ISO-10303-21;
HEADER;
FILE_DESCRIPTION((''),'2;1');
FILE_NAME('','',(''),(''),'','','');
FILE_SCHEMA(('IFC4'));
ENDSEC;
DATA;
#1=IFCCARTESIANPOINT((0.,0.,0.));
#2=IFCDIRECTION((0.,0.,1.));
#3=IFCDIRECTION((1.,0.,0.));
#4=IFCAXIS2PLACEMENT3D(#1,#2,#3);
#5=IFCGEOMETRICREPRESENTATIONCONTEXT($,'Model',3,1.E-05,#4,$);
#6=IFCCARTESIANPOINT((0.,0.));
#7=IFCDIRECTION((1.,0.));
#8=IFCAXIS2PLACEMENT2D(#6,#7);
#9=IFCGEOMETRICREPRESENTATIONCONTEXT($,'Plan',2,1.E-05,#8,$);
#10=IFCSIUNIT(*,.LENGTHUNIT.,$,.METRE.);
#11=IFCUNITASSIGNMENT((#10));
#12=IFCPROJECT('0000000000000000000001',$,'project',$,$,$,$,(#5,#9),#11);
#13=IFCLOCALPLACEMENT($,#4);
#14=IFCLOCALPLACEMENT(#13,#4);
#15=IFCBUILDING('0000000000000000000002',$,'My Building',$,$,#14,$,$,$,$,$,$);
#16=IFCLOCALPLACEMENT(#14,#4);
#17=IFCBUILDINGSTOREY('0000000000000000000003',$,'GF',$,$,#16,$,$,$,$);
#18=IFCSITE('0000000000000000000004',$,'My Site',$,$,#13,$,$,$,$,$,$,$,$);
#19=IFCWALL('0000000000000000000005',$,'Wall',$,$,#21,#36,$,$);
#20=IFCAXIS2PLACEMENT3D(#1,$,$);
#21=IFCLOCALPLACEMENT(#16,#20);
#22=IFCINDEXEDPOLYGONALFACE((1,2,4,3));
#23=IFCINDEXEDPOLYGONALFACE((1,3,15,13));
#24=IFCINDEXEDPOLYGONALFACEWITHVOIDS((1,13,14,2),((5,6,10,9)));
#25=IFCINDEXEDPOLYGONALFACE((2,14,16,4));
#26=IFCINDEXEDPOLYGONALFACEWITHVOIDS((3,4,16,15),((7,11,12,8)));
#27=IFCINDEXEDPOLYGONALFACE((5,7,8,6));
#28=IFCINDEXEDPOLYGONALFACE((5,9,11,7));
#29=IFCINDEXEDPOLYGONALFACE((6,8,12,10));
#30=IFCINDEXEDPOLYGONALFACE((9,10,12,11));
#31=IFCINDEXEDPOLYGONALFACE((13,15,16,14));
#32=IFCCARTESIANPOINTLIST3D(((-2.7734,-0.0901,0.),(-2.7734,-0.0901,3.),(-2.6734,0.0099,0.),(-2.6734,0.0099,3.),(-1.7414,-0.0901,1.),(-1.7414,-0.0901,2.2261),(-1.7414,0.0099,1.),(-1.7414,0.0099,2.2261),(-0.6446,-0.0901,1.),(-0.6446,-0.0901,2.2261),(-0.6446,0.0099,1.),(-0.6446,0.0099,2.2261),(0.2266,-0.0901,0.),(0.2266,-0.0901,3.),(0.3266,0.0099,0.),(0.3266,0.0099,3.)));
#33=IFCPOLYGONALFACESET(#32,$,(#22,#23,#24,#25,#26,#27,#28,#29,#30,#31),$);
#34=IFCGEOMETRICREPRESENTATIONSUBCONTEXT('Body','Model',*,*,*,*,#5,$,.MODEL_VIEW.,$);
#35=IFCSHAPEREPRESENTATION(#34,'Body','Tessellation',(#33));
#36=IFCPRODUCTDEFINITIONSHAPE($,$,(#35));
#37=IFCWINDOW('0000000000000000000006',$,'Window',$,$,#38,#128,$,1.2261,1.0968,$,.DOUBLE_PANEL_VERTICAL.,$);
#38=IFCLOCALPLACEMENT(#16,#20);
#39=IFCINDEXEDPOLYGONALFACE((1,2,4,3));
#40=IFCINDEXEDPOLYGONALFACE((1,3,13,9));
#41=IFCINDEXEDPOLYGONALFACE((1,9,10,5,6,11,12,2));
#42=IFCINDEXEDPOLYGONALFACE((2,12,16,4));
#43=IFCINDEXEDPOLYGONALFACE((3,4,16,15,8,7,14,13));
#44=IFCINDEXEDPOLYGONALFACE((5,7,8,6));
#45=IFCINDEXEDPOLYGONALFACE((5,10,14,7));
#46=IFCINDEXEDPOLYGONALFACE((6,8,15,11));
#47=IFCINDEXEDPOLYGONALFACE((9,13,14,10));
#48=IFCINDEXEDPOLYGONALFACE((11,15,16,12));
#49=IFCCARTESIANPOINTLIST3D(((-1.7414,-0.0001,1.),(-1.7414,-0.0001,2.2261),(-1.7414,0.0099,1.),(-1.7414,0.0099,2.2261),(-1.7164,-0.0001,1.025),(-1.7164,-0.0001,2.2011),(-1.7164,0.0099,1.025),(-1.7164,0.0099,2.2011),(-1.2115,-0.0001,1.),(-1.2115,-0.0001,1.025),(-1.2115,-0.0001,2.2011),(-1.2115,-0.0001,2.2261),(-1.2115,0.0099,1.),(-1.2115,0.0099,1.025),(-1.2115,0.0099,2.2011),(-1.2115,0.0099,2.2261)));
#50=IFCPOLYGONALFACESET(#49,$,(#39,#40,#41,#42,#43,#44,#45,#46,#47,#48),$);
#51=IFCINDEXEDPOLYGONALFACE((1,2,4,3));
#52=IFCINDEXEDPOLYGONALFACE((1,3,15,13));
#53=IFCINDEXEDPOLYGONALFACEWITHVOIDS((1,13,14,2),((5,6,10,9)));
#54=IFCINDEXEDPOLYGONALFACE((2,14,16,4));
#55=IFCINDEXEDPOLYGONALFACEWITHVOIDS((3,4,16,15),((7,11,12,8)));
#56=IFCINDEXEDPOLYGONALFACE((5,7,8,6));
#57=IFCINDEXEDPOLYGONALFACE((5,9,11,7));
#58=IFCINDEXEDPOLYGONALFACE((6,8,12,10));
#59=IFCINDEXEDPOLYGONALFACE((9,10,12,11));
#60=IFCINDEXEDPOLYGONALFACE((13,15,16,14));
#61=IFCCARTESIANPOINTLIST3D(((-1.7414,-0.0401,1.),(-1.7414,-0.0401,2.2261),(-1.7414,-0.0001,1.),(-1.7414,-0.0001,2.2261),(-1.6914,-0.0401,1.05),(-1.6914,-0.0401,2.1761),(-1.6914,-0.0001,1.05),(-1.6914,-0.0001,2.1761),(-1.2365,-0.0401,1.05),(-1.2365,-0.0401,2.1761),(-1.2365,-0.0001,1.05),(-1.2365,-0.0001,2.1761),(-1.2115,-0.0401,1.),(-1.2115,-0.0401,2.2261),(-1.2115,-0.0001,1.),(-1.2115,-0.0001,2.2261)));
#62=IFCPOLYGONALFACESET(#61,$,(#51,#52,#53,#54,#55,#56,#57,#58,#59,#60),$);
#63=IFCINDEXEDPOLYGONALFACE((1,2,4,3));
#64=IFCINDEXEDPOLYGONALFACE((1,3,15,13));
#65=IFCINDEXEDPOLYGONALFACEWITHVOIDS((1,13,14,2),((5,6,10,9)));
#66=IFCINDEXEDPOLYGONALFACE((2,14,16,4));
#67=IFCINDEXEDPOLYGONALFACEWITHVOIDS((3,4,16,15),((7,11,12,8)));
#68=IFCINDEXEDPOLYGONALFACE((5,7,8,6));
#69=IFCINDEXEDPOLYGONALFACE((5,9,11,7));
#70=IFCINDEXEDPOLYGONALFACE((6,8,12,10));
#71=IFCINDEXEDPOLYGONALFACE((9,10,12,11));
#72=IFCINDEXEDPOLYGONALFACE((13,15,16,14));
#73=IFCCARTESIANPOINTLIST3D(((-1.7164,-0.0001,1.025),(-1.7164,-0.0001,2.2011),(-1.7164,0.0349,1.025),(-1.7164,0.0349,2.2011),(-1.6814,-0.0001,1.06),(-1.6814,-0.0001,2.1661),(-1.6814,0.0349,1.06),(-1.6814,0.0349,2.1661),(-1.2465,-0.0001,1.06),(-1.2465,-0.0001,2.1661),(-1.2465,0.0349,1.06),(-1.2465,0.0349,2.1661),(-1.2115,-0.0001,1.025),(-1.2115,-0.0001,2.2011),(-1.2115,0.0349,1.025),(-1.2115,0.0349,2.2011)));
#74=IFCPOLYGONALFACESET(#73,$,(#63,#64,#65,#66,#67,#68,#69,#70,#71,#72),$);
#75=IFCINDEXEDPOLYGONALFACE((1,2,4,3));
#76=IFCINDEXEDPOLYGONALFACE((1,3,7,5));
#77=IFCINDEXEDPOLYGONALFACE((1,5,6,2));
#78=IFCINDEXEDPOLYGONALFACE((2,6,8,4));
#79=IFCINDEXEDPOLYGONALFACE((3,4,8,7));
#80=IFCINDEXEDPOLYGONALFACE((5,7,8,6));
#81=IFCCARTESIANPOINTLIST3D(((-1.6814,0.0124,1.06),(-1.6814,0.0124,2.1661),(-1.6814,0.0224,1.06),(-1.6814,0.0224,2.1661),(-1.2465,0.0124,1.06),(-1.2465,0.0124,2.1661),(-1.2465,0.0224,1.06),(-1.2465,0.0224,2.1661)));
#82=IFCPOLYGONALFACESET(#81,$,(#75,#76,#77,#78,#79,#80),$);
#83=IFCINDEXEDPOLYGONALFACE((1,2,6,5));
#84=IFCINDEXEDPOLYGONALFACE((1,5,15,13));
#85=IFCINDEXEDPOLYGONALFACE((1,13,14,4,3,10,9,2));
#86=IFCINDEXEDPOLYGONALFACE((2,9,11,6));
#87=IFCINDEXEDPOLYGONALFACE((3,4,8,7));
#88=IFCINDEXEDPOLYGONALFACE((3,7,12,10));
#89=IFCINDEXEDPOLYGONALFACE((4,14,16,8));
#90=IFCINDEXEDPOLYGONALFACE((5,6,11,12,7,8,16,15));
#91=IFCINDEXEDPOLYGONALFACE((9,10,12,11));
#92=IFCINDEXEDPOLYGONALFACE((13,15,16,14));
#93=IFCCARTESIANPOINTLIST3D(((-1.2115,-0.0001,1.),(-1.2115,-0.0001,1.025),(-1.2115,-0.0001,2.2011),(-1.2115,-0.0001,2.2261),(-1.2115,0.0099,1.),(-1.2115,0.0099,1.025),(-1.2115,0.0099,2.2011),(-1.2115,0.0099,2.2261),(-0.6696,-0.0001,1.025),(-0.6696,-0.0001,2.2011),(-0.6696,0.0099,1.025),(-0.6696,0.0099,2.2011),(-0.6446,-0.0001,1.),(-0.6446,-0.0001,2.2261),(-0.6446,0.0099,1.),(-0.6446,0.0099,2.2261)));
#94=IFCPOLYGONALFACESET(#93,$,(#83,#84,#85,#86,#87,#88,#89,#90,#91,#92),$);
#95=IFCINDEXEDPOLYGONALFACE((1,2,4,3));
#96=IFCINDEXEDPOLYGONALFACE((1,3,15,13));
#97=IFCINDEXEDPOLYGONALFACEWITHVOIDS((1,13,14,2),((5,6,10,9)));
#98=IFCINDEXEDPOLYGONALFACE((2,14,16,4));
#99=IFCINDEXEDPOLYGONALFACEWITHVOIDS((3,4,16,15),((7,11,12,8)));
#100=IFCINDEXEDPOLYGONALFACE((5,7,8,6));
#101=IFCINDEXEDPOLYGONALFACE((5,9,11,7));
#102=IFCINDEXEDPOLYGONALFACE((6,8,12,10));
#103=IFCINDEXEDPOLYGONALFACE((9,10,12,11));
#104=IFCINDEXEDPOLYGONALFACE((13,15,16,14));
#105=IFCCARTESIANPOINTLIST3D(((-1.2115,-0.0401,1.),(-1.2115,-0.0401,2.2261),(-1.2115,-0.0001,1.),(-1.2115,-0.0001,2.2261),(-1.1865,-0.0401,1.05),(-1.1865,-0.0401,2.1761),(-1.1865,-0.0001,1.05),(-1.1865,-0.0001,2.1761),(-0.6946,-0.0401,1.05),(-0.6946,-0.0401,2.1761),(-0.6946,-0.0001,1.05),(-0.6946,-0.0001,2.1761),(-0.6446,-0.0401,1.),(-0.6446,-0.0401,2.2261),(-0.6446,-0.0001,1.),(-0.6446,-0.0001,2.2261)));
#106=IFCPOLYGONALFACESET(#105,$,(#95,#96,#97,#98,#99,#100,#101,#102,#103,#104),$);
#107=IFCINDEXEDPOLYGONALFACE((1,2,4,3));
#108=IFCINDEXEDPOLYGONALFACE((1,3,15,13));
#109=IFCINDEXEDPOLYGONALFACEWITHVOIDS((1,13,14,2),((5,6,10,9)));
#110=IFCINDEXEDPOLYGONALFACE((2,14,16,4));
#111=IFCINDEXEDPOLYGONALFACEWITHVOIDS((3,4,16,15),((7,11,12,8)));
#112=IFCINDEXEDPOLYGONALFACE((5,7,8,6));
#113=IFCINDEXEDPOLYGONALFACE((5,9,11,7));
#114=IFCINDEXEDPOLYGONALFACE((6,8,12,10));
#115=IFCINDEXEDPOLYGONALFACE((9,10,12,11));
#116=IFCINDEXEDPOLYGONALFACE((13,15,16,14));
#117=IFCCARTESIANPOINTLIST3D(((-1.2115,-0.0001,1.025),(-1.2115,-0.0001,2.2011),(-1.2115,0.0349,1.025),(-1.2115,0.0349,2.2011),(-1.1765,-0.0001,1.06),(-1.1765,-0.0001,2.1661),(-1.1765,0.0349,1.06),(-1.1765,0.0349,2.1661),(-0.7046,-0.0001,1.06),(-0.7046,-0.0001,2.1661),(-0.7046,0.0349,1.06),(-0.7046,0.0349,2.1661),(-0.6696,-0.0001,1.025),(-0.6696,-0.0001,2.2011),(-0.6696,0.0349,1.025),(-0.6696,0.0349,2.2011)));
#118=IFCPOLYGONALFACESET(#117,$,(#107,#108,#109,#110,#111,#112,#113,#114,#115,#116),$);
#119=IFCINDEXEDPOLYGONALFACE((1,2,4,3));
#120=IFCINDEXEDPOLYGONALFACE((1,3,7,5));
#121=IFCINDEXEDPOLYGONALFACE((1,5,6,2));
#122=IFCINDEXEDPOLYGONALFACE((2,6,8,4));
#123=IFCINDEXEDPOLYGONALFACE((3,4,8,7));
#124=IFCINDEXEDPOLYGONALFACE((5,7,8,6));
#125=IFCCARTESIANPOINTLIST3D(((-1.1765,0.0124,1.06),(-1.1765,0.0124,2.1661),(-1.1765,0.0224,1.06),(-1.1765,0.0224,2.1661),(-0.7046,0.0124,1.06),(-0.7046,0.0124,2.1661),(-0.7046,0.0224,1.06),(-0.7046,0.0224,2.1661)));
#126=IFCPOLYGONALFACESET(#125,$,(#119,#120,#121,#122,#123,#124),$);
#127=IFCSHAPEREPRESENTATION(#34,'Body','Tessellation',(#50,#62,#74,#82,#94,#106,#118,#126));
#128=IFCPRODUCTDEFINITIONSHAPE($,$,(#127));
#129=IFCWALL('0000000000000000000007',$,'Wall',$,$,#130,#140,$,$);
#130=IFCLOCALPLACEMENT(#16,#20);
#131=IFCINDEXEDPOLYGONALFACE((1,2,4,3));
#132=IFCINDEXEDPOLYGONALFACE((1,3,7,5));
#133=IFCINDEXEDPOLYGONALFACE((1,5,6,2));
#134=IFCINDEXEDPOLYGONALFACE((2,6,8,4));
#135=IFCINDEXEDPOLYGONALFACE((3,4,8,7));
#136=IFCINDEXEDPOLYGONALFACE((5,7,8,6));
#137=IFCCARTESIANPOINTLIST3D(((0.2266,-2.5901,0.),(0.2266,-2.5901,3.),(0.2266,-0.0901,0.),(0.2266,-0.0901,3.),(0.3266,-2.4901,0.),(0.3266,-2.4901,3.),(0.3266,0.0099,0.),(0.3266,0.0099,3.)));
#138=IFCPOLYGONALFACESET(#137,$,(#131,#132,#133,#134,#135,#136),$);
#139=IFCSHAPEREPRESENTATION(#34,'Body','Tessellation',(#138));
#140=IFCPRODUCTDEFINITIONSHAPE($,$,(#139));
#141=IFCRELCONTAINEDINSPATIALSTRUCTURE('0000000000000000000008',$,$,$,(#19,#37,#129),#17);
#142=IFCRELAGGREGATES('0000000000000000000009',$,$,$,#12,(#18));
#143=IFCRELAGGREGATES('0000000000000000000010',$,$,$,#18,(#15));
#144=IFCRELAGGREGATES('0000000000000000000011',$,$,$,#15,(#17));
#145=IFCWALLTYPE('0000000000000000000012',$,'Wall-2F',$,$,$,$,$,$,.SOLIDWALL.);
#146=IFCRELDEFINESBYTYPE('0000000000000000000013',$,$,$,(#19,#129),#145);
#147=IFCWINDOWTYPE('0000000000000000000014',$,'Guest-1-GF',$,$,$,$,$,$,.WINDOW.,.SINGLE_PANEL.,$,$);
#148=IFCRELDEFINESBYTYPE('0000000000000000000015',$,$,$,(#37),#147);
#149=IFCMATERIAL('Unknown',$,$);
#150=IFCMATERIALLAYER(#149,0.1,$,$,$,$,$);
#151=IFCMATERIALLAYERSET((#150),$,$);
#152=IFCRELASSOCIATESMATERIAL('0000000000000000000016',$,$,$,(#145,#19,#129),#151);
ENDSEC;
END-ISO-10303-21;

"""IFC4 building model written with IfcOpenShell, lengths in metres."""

from ifc_helpers import new_model, entity, si_unit, frame, origin_with_axes, origin_2d_with_axis, place, context, subcontext, project, spatial, line, indexed_curve, outline, extrude, shape, source, transform, mapped, material, layer, layer_set, layer_usage, type_object, type_shapes, element, fill, save


model = new_model("IFC4")

# Units and contexts
model_context = context("Model", 3, precision=1e-05, world=origin_with_axes())
plan_context = context("Plan", 2, precision=1e-05, world=origin_2d_with_axis())
body_context_1 = subcontext(model_context, "Body", "Model", "MODEL_VIEW")
body_context_2 = subcontext(plan_context, "Body", "Plan", "PLAN_VIEW")
ifc_project = project(units=[si_unit("LENGTHUNIT", "METRE")], contexts=[model_context, plan_context])

# Site, building, storey
site_placement = place(None, origin_with_axes())
site = spatial("IfcSite", under=ifc_project, at=site_placement, Name="My Site")
building_placement = place(site_placement, origin_with_axes())
building = spatial("IfcBuilding", under=site, at=building_placement, Name="My Building")
storey_placement = place(building_placement, origin_with_axes())
storey = spatial("IfcBuildingStorey", under=building, at=storey_placement, Name="GF")

# Shared definitions
ifc_material = material(Name="Unknown")

# Shared definitions
ifc_layer_1 = layer(ifc_material, 0.1)
ifc_layer_set_1 = layer_set([ifc_layer_1])
wall_type = type_object("IfcWallType", Name="Wall-2F", PredefinedType="SOLIDWALL", material=ifc_layer_set_1)

# Wall, opening, window
ifc_layer_usage_1 = layer_usage(ifc_layer_set_1, "AXIS2", "POSITIVE", 0.0)
wall_1_placement = place(storey_placement, frame((-2.7734, -0.0901, 0.0), z_axis=(0.0, 0.0, 1.0), x_axis=(1.0, 0.0, 0.0)))
wall_1 = element("IfcWall", 1, at=wall_1_placement, inside=storey, type_object=wall_type, material=ifc_layer_usage_1, Name="Wall", context=body_context_1, shape_type="SweptSolid", body=[
    extrude(outline(indexed_curve([(0.0, 0.0), (0.1, 0.1), (3.1, 0.1), (3.0, 0.0)], segments=[line(1, 2, 3, 4, 1)])), origin_with_axes(), (0.0, 0.0, 1.0), 3.0),
])
shared_shape_1 = source(origin_with_axes(), body_context_1, "Body", "SweptSolid", [
    extrude(outline(indexed_curve([(0.0, 0.0), (1.0968, 0.0), (1.0968, 1.2261), (0.0, 1.2261)], segments=[line(1, 2, 3, 4, 1)])), frame((0.0, -0.6, 0.0), z_axis=(0.0, -1.0, 0.0), x_axis=(1.0, 0.0, 0.0)), (0.0, 0.0, -1.0), 1.2),
])
opening_1_placement = place(wall_1_placement, frame((1.032, 0.0, 1.0), z_axis=(0.0, 0.0, 1.0), x_axis=(1.0, 0.0, 0.0)))
opening_1 = element("IfcOpeningElement", 2, at=opening_1_placement, cuts=wall_1, PredefinedType="OPENING", context=body_context_1, shape_type="MappedRepresentation", body=[
    mapped(shared_shape_1, transform((0.0, 0.0, 0.0), x_axis=(1.0, 0.0, 0.0), y_axis=(0.0, 1.0, 0.0), z_axis=(0.0, 0.0, 1.0), scale=1.0)),
])
window_type_1 = type_object("IfcWindowType", Name="Guest-1-GF", PartitioningType="SINGLE_PANEL", PredefinedType="WINDOW")
shared_shape_2 = source(origin_with_axes(), body_context_1, "Body", "SweptSolid", [
    extrude(outline(indexed_curve([(0.5299, 0.0), (0.0, 0.0), (0.0, 1.2261), (0.5299, 1.2261), (0.5299, 1.2011), (0.025, 1.2011), (0.025, 0.025), (0.5299, 0.025)], segments=[line(1, 2, 3, 4, 5, 6, 7, 8, 1)])), frame((0.0, 0.09, 0.0), z_axis=(0.0, -1.0, 0.0), x_axis=(1.0, 0.0, 0.0)), (0.0, 0.0, -1.0), 0.01),
    extrude(outline(indexed_curve([(0.0, 0.0), (0.5299, 0.0), (0.5299, 1.2261), (0.0, 1.2261)], segments=[line(1, 2, 3, 4, 1)]), holes=[indexed_curve([(0.05, 0.05), (0.5049, 0.05), (0.5049, 1.1761), (0.05, 1.1761)], segments=[line(1, 2, 3, 4, 1)])]), frame((0.0, 0.05, 0.0), z_axis=(0.0, -1.0, 0.0), x_axis=(1.0, 0.0, 0.0)), (0.0, 0.0, -1.0), 0.04),
    extrude(outline(indexed_curve([(0.0, 0.0), (0.5049, 0.0), (0.5049, 1.1761), (0.0, 1.1761)], segments=[line(1, 2, 3, 4, 1)]), holes=[indexed_curve([(0.035, 0.035), (0.4699, 0.035), (0.4699, 1.1411), (0.035, 1.1411)], segments=[line(1, 2, 3, 4, 1)])]), frame((0.025, 0.09, 0.025), z_axis=(0.0, -1.0, 0.0), x_axis=(1.0, 0.0, 0.0)), (0.0, 0.0, -1.0), 0.035),
    extrude(outline(indexed_curve([(0.035, 0.035), (0.4699, 0.035), (0.4699, 1.1411), (0.035, 1.1411)], segments=[line(1, 2, 3, 4, 1)])), frame((0.025, 0.1025, 0.025), z_axis=(0.0, -1.0, 0.0), x_axis=(1.0, 0.0, 0.0)), (0.0, 0.0, -1.0), 0.01),
    extrude(outline(indexed_curve([(0.0, 1.2261), (0.5669, 1.2261), (0.5669, 0.0), (0.0, 0.0), (0.0, 0.025), (0.5419, 0.025), (0.5419, 1.2011), (0.0, 1.2011)], segments=[line(1, 2, 3, 4, 5, 6, 7, 8, 1)])), frame((0.5299, 0.09, 0.0), z_axis=(0.0, -1.0, 0.0), x_axis=(1.0, 0.0, 0.0)), (0.0, 0.0, -1.0), 0.01),
    extrude(outline(indexed_curve([(0.0, 0.0), (0.5669, 0.0), (0.5669, 1.2261), (0.0, 1.2261)], segments=[line(1, 2, 3, 4, 1)]), holes=[indexed_curve([(0.025, 0.05), (0.5169, 0.05), (0.5169, 1.1761), (0.025, 1.1761)], segments=[line(1, 2, 3, 4, 1)])]), frame((0.5299, 0.05, 0.0), z_axis=(0.0, -1.0, 0.0), x_axis=(1.0, 0.0, 0.0)), (0.0, 0.0, -1.0), 0.04),
    extrude(outline(indexed_curve([(0.0, 0.0), (0.5419, 0.0), (0.5419, 1.1761), (0.0, 1.1761)], segments=[line(1, 2, 3, 4, 1)]), holes=[indexed_curve([(0.035, 0.035), (0.5069, 0.035), (0.5069, 1.1411), (0.035, 1.1411)], segments=[line(1, 2, 3, 4, 1)])]), frame((0.5299, 0.09, 0.025), z_axis=(0.0, -1.0, 0.0), x_axis=(1.0, 0.0, 0.0)), (0.0, 0.0, -1.0), 0.035),
    extrude(outline(indexed_curve([(0.035, 0.035), (0.5069, 0.035), (0.5069, 1.1411), (0.035, 1.1411)], segments=[line(1, 2, 3, 4, 1)])), frame((0.5299, 0.1025, 0.025), z_axis=(0.0, -1.0, 0.0), x_axis=(1.0, 0.0, 0.0)), (0.0, 0.0, -1.0), 0.01),
])
shared_shape_3 = source(origin_with_axes(), body_context_2, "Body", "Curve2D", [
    entity("IfcIndexedPolyCurve", entity("IfcCartesianPointList2D", [[0.05, 0.05], [0.5049, 0.05]])),
    entity("IfcIndexedPolyCurve", entity("IfcCartesianPointList2D", [[0.0, 0.1], [0.025, 0.1], [0.025, 0.09], [0.05, 0.09], [0.05, 0.05], [0.0, 0.05]]), [entity("IfcLineIndex", [1, 2, 3, 4, 5, 6, 1])]),
    entity("IfcIndexedPolyCurve", entity("IfcCartesianPointList2D", [[0.5299, 0.1], [0.5299, 0.1], [0.5299, 0.09], [0.5049, 0.09], [0.5049, 0.05], [0.5299, 0.05]])),
    entity("IfcIndexedPolyCurve", entity("IfcCartesianPointList2D", [[0.025, 0.09], [0.06, 0.09], [0.06, 0.125], [0.025, 0.125]]), [entity("IfcLineIndex", [1, 2, 3, 4, 1])]),
    entity("IfcIndexedPolyCurve", entity("IfcCartesianPointList2D", [[0.5299, 0.09], [0.4949, 0.09], [0.4949, 0.125], [0.5299, 0.125]]), [entity("IfcLineIndex", [1, 2, 3, 4, 1])]),
    entity("IfcIndexedPolyCurve", entity("IfcCartesianPointList2D", [[0.06, 0.09], [0.4949, 0.09]])),
    entity("IfcIndexedPolyCurve", entity("IfcCartesianPointList2D", [[0.06, 0.125], [0.4949, 0.125]])),
    entity("IfcIndexedPolyCurve", entity("IfcCartesianPointList2D", [[0.06, 0.1075], [0.4949, 0.1075]])),
    entity("IfcIndexedPolyCurve", entity("IfcCartesianPointList2D", [[0.5549, 0.05], [1.0468, 0.05]])),
    entity("IfcIndexedPolyCurve", entity("IfcCartesianPointList2D", [[0.5299, 0.1], [0.5299, 0.1], [0.5299, 0.09], [0.5549, 0.09], [0.5549, 0.05], [0.5299, 0.05]])),
    entity("IfcIndexedPolyCurve", entity("IfcCartesianPointList2D", [[1.0968, 0.1], [1.0718, 0.1], [1.0718, 0.09], [1.0468, 0.09], [1.0468, 0.05], [1.0968, 0.05]]), [entity("IfcLineIndex", [1, 2, 3, 4, 5, 6, 1])]),
    entity("IfcIndexedPolyCurve", entity("IfcCartesianPointList2D", [[0.5299, 0.09], [0.5649, 0.09], [0.5649, 0.125], [0.5299, 0.125]]), [entity("IfcLineIndex", [1, 2, 3, 4, 1])]),
    entity("IfcIndexedPolyCurve", entity("IfcCartesianPointList2D", [[1.0718, 0.09], [1.0368, 0.09], [1.0368, 0.125], [1.0718, 0.125]]), [entity("IfcLineIndex", [1, 2, 3, 4, 1])]),
    entity("IfcIndexedPolyCurve", entity("IfcCartesianPointList2D", [[0.5649, 0.09], [1.0368, 0.09]])),
    entity("IfcIndexedPolyCurve", entity("IfcCartesianPointList2D", [[0.5649, 0.125], [1.0368, 0.125]])),
    entity("IfcIndexedPolyCurve", entity("IfcCartesianPointList2D", [[0.5649, 0.1075], [1.0368, 0.1075]])),
])
type_shapes(window_type_1, [shared_shape_2, shared_shape_3])
window_1_placement = place(opening_1_placement, origin_with_axes())
window_1 = element("IfcWindow", 3, at=window_1_placement, inside=storey, type_object=window_type_1, Name="Window", OverallHeight=1.2261, OverallWidth=1.0968, PartitioningType="DOUBLE_PANEL_VERTICAL", shapes=[
    shape(body_context_1, "Body", "MappedRepresentation", [mapped(shared_shape_2, transform((0.0, 0.0, 0.0), x_axis=(1.0, 0.0, 0.0), y_axis=(0.0, 1.0, 0.0), z_axis=(0.0, 0.0, 1.0), scale=1.0))]),
    shape(body_context_2, "Body", "MappedRepresentation", [mapped(shared_shape_3, transform((0.0, 0.0, 0.0), x_axis=(1.0, 0.0, 0.0), y_axis=(0.0, 1.0, 0.0), z_axis=(0.0, 0.0, 1.0), scale=1.0))]),
])
fill(opening_1, window_1)

# Wall
ifc_layer_usage_2 = layer_usage(ifc_layer_set_1, "AXIS2", "POSITIVE", 0.0)
wall_2_placement = place(storey_placement, frame((0.2266, -0.0901, 0.0), z_axis=(0.0, 0.0, 1.0), x_axis=(-0.000001, -1.0, 0.0)))
element("IfcWall", 4, at=wall_2_placement, inside=storey, type_object=wall_type, material=ifc_layer_usage_2, Name="Wall", context=body_context_1, shape_type="SweptSolid", body=[
    extrude(outline(indexed_curve([(0.0, 0.0), (-0.1, 0.1), (2.4, 0.1), (2.5, 0.0)], segments=[line(1, 2, 3, 4, 1)])), origin_with_axes(), (0.0, 0.0, 1.0), 3.0),
])

save(model, "model.ifc")
